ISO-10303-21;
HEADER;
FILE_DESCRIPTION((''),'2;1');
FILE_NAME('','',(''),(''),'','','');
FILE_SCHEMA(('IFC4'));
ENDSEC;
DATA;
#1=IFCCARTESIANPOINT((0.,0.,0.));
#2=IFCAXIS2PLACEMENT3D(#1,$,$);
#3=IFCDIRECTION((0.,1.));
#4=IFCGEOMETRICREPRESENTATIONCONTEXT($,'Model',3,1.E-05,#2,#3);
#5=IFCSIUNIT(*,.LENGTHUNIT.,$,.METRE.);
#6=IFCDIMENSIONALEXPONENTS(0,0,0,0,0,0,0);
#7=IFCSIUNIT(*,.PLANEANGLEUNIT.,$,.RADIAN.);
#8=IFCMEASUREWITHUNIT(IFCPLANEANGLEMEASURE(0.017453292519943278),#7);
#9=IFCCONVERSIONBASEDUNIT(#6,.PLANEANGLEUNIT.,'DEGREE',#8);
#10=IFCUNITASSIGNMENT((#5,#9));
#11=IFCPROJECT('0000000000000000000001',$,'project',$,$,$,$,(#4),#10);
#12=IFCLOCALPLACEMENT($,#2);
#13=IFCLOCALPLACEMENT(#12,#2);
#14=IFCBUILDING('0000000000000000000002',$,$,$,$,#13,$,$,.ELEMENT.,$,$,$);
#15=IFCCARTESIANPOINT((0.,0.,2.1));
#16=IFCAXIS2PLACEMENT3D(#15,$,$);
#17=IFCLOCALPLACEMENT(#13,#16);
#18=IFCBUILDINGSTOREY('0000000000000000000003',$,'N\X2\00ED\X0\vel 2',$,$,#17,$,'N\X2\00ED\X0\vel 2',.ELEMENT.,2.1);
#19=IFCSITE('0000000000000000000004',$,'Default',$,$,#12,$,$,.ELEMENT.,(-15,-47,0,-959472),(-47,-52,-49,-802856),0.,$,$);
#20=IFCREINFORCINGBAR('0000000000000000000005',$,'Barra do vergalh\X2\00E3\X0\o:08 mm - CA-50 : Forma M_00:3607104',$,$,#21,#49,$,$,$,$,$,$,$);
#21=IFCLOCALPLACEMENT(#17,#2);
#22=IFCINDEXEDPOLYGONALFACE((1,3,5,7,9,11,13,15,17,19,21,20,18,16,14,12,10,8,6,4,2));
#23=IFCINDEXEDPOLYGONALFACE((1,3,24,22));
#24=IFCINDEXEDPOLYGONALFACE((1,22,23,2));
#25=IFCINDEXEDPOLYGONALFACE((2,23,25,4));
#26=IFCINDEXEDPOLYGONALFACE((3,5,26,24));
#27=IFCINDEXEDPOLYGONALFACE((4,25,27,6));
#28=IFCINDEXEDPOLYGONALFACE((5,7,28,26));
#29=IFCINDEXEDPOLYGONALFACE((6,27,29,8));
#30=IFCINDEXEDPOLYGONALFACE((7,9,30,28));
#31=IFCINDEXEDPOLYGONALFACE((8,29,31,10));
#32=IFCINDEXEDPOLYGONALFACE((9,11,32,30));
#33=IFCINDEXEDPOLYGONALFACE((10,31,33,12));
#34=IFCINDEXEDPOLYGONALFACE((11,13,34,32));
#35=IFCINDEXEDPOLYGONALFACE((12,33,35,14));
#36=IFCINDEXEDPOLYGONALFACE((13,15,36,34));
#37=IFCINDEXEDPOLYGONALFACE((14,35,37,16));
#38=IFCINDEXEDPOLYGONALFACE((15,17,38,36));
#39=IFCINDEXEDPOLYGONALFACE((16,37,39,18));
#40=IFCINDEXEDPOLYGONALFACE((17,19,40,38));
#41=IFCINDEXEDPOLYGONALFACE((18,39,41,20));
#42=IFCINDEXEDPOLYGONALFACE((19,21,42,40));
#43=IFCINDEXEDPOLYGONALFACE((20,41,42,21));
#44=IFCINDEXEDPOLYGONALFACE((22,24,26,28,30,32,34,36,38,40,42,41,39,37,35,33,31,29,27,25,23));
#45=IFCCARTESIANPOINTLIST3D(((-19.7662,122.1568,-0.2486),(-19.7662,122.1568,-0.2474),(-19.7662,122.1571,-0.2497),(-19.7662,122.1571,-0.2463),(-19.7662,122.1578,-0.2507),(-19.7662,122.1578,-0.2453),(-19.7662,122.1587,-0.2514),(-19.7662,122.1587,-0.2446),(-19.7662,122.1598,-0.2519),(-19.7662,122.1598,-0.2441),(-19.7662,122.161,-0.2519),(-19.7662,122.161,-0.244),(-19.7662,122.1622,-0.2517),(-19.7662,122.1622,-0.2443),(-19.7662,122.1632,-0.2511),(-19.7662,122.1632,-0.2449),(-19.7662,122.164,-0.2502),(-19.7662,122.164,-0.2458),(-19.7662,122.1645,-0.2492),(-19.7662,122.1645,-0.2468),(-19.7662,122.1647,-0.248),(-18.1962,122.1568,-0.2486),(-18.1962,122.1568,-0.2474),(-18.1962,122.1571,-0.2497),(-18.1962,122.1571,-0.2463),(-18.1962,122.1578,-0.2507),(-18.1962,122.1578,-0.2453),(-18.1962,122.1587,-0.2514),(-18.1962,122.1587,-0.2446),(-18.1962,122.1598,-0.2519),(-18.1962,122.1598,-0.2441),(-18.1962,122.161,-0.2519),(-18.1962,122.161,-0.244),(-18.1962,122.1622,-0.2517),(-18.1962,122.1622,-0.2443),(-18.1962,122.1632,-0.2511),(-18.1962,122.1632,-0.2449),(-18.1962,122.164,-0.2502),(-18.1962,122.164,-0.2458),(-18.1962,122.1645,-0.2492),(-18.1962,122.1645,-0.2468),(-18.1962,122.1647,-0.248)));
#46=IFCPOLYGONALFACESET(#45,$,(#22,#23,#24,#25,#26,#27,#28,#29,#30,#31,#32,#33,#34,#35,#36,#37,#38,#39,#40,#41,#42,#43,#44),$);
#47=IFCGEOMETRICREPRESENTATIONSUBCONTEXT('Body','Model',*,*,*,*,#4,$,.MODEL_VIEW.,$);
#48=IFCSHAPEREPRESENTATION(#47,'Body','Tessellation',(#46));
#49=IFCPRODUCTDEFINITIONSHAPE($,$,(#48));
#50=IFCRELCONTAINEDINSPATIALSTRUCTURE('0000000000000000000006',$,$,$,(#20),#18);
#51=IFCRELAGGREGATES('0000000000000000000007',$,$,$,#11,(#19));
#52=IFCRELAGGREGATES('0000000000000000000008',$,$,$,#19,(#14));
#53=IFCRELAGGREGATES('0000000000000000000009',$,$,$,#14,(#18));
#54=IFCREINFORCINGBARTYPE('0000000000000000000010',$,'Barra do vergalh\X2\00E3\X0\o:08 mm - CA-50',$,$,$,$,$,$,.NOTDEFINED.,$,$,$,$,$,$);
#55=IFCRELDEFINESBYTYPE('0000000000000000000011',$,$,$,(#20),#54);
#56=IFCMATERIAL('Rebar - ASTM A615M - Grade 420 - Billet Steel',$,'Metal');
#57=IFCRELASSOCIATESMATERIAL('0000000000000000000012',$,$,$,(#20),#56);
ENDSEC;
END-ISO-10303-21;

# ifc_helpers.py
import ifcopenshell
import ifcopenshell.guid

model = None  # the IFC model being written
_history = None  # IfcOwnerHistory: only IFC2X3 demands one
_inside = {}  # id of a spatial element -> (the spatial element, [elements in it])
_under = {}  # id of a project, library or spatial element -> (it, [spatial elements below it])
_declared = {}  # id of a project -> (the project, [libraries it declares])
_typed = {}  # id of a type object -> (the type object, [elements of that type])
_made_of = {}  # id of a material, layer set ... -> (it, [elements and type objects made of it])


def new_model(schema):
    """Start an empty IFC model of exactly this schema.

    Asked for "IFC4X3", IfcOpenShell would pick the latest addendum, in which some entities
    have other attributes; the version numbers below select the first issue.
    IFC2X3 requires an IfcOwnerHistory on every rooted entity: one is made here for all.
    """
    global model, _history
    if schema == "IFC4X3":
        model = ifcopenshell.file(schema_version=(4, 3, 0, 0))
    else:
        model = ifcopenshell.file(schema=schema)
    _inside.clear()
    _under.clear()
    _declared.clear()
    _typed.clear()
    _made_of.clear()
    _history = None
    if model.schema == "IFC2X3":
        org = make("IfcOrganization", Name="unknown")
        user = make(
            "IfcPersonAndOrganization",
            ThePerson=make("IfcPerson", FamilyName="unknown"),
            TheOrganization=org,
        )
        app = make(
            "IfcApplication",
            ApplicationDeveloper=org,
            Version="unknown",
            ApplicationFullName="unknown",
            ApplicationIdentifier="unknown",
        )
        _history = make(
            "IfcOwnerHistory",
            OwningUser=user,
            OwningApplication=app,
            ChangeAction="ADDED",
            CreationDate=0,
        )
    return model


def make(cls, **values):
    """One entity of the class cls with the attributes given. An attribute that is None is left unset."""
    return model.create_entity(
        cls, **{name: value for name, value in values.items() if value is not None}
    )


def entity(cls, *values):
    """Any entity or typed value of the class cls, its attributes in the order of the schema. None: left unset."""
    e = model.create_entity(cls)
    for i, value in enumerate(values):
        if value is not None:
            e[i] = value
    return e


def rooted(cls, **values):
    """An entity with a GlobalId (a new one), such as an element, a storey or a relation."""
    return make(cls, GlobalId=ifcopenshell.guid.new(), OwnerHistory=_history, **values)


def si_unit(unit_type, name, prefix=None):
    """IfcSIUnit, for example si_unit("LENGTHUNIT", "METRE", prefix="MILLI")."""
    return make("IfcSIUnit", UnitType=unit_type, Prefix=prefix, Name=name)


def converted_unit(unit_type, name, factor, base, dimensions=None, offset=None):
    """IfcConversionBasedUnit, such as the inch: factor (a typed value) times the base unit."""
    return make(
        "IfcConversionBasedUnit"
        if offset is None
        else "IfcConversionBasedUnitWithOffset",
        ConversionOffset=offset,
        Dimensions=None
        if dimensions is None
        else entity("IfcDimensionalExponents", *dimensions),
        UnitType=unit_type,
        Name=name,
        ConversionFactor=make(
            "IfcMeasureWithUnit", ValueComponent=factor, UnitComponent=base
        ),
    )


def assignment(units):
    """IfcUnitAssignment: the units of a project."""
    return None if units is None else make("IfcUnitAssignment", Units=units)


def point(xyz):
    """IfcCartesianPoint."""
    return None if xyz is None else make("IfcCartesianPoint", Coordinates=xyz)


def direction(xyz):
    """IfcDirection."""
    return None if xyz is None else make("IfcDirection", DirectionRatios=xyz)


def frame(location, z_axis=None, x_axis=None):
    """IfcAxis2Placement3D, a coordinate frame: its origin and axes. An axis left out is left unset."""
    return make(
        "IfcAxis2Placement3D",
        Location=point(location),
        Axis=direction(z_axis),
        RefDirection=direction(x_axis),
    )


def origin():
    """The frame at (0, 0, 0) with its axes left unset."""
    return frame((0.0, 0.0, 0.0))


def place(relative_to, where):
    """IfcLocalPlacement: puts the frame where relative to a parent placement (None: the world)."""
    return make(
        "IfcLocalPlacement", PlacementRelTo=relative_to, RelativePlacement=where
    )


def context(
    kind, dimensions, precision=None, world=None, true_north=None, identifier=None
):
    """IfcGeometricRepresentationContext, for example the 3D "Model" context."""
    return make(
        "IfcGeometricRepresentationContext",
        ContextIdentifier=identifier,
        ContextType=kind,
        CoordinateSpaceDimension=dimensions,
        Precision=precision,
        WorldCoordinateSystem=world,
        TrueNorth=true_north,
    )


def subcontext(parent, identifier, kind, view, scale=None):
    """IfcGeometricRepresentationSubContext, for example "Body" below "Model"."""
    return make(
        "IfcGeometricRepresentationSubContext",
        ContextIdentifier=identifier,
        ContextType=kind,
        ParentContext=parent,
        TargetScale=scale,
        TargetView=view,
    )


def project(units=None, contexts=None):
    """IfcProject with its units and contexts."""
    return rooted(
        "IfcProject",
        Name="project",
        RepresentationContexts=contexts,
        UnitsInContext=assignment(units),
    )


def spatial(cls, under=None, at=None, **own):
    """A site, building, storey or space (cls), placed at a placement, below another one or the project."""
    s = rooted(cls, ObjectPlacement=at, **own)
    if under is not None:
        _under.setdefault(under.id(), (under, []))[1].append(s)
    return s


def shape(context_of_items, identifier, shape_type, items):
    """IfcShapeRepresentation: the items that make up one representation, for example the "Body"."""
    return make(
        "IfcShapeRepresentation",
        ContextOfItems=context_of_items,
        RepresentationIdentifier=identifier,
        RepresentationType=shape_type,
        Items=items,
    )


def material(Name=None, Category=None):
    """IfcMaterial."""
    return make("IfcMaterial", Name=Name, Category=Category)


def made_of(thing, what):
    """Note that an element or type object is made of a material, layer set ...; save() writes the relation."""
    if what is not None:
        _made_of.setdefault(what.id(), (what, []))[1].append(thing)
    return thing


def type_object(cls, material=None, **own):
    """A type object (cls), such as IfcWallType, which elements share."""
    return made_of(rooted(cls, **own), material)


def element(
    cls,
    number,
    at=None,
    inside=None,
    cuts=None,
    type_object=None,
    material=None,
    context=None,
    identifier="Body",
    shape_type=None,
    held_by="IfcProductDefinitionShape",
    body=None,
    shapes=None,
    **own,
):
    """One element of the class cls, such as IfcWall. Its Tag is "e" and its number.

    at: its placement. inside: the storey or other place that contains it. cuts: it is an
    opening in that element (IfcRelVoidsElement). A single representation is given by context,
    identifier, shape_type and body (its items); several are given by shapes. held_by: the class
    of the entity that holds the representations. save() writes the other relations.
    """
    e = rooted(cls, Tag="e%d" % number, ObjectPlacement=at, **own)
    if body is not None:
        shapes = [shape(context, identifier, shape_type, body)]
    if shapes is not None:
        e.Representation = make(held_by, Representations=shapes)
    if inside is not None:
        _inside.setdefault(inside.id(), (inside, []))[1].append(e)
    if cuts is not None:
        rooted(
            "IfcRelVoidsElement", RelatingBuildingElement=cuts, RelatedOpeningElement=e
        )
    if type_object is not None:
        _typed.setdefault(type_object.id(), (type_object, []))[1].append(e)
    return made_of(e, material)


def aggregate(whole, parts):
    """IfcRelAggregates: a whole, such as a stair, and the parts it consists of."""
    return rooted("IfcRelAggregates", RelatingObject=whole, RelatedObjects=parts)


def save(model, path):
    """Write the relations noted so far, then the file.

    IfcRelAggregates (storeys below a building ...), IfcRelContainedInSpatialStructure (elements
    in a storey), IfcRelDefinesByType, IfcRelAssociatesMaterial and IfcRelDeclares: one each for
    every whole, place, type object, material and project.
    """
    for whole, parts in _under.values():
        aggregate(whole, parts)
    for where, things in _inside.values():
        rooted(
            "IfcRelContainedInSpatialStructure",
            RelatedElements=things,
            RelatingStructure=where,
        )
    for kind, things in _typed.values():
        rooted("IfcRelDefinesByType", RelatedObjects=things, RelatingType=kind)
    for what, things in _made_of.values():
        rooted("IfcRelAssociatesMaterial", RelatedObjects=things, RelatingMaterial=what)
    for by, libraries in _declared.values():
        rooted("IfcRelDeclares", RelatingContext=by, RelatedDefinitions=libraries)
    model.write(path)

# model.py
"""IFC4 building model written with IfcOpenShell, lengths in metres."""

from ifc_helpers import new_model, entity, si_unit, converted_unit, direction, frame, origin, place, context, subcontext, project, spatial, material, type_object, element, save


model = new_model("IFC4")

# Units and contexts
model_context = context("Model", 3, precision=1e-05, world=origin(), true_north=direction((0.0, 1.0)))
body_context = subcontext(model_context, "Body", "Model", "MODEL_VIEW")
ifc_project = project(units=[si_unit("LENGTHUNIT", "METRE"), converted_unit("PLANEANGLEUNIT", "DEGREE", entity("IfcPlaneAngleMeasure", 0.017453292519943278), si_unit("PLANEANGLEUNIT", "RADIAN"), dimensions=[0, 0, 0, 0, 0, 0, 0])], contexts=[model_context])

# Site, building, storey
site_placement = place(None, origin())
site = spatial("IfcSite", under=ifc_project, at=site_placement, Name="Default", CompositionType="ELEMENT", RefLatitude=(-15, -47, 0, -959472), RefLongitude=(-47, -52, -49, -802856), RefElevation=0.0)
building_placement = place(site_placement, origin())
building = spatial("IfcBuilding", under=site, at=building_placement, CompositionType="ELEMENT")
storey_placement = place(building_placement, frame((0.0, 0.0, 2.1)))
storey = spatial("IfcBuildingStorey", under=building, at=storey_placement, Name="Nível 2", LongName="Nível 2", CompositionType="ELEMENT", Elevation=2.1)

# Reinforcing bar
ifc_material_1 = material(Name="Rebar - ASTM A615M - Grade 420 - Billet Steel", Category="Metal")
reinforcing_bar_type_1 = type_object("IfcReinforcingBarType", Name="Barra do vergalhão:08 mm - CA-50", PredefinedType="NOTDEFINED")
reinforcing_bar_1_placement = place(storey_placement, origin())
element("IfcReinforcingBar", 1, at=reinforcing_bar_1_placement, inside=storey, type_object=reinforcing_bar_type_1, material=ifc_material_1, Name="Barra do vergalhão:08 mm - CA-50 : Forma M_00:3607104", context=body_context, shape_type="AdvancedSweptSolid", body=[
    entity("IfcSweptDiskSolid", entity("IfcIndexedPolyCurve", entity("IfcCartesianPointList3D", [[18.1962, -122.1607, 0.248], [19.7662, -122.1607, 0.248]]), None, False), 0.004, None, 0.0, 1.0),
])

save(model, "model.ifc")
